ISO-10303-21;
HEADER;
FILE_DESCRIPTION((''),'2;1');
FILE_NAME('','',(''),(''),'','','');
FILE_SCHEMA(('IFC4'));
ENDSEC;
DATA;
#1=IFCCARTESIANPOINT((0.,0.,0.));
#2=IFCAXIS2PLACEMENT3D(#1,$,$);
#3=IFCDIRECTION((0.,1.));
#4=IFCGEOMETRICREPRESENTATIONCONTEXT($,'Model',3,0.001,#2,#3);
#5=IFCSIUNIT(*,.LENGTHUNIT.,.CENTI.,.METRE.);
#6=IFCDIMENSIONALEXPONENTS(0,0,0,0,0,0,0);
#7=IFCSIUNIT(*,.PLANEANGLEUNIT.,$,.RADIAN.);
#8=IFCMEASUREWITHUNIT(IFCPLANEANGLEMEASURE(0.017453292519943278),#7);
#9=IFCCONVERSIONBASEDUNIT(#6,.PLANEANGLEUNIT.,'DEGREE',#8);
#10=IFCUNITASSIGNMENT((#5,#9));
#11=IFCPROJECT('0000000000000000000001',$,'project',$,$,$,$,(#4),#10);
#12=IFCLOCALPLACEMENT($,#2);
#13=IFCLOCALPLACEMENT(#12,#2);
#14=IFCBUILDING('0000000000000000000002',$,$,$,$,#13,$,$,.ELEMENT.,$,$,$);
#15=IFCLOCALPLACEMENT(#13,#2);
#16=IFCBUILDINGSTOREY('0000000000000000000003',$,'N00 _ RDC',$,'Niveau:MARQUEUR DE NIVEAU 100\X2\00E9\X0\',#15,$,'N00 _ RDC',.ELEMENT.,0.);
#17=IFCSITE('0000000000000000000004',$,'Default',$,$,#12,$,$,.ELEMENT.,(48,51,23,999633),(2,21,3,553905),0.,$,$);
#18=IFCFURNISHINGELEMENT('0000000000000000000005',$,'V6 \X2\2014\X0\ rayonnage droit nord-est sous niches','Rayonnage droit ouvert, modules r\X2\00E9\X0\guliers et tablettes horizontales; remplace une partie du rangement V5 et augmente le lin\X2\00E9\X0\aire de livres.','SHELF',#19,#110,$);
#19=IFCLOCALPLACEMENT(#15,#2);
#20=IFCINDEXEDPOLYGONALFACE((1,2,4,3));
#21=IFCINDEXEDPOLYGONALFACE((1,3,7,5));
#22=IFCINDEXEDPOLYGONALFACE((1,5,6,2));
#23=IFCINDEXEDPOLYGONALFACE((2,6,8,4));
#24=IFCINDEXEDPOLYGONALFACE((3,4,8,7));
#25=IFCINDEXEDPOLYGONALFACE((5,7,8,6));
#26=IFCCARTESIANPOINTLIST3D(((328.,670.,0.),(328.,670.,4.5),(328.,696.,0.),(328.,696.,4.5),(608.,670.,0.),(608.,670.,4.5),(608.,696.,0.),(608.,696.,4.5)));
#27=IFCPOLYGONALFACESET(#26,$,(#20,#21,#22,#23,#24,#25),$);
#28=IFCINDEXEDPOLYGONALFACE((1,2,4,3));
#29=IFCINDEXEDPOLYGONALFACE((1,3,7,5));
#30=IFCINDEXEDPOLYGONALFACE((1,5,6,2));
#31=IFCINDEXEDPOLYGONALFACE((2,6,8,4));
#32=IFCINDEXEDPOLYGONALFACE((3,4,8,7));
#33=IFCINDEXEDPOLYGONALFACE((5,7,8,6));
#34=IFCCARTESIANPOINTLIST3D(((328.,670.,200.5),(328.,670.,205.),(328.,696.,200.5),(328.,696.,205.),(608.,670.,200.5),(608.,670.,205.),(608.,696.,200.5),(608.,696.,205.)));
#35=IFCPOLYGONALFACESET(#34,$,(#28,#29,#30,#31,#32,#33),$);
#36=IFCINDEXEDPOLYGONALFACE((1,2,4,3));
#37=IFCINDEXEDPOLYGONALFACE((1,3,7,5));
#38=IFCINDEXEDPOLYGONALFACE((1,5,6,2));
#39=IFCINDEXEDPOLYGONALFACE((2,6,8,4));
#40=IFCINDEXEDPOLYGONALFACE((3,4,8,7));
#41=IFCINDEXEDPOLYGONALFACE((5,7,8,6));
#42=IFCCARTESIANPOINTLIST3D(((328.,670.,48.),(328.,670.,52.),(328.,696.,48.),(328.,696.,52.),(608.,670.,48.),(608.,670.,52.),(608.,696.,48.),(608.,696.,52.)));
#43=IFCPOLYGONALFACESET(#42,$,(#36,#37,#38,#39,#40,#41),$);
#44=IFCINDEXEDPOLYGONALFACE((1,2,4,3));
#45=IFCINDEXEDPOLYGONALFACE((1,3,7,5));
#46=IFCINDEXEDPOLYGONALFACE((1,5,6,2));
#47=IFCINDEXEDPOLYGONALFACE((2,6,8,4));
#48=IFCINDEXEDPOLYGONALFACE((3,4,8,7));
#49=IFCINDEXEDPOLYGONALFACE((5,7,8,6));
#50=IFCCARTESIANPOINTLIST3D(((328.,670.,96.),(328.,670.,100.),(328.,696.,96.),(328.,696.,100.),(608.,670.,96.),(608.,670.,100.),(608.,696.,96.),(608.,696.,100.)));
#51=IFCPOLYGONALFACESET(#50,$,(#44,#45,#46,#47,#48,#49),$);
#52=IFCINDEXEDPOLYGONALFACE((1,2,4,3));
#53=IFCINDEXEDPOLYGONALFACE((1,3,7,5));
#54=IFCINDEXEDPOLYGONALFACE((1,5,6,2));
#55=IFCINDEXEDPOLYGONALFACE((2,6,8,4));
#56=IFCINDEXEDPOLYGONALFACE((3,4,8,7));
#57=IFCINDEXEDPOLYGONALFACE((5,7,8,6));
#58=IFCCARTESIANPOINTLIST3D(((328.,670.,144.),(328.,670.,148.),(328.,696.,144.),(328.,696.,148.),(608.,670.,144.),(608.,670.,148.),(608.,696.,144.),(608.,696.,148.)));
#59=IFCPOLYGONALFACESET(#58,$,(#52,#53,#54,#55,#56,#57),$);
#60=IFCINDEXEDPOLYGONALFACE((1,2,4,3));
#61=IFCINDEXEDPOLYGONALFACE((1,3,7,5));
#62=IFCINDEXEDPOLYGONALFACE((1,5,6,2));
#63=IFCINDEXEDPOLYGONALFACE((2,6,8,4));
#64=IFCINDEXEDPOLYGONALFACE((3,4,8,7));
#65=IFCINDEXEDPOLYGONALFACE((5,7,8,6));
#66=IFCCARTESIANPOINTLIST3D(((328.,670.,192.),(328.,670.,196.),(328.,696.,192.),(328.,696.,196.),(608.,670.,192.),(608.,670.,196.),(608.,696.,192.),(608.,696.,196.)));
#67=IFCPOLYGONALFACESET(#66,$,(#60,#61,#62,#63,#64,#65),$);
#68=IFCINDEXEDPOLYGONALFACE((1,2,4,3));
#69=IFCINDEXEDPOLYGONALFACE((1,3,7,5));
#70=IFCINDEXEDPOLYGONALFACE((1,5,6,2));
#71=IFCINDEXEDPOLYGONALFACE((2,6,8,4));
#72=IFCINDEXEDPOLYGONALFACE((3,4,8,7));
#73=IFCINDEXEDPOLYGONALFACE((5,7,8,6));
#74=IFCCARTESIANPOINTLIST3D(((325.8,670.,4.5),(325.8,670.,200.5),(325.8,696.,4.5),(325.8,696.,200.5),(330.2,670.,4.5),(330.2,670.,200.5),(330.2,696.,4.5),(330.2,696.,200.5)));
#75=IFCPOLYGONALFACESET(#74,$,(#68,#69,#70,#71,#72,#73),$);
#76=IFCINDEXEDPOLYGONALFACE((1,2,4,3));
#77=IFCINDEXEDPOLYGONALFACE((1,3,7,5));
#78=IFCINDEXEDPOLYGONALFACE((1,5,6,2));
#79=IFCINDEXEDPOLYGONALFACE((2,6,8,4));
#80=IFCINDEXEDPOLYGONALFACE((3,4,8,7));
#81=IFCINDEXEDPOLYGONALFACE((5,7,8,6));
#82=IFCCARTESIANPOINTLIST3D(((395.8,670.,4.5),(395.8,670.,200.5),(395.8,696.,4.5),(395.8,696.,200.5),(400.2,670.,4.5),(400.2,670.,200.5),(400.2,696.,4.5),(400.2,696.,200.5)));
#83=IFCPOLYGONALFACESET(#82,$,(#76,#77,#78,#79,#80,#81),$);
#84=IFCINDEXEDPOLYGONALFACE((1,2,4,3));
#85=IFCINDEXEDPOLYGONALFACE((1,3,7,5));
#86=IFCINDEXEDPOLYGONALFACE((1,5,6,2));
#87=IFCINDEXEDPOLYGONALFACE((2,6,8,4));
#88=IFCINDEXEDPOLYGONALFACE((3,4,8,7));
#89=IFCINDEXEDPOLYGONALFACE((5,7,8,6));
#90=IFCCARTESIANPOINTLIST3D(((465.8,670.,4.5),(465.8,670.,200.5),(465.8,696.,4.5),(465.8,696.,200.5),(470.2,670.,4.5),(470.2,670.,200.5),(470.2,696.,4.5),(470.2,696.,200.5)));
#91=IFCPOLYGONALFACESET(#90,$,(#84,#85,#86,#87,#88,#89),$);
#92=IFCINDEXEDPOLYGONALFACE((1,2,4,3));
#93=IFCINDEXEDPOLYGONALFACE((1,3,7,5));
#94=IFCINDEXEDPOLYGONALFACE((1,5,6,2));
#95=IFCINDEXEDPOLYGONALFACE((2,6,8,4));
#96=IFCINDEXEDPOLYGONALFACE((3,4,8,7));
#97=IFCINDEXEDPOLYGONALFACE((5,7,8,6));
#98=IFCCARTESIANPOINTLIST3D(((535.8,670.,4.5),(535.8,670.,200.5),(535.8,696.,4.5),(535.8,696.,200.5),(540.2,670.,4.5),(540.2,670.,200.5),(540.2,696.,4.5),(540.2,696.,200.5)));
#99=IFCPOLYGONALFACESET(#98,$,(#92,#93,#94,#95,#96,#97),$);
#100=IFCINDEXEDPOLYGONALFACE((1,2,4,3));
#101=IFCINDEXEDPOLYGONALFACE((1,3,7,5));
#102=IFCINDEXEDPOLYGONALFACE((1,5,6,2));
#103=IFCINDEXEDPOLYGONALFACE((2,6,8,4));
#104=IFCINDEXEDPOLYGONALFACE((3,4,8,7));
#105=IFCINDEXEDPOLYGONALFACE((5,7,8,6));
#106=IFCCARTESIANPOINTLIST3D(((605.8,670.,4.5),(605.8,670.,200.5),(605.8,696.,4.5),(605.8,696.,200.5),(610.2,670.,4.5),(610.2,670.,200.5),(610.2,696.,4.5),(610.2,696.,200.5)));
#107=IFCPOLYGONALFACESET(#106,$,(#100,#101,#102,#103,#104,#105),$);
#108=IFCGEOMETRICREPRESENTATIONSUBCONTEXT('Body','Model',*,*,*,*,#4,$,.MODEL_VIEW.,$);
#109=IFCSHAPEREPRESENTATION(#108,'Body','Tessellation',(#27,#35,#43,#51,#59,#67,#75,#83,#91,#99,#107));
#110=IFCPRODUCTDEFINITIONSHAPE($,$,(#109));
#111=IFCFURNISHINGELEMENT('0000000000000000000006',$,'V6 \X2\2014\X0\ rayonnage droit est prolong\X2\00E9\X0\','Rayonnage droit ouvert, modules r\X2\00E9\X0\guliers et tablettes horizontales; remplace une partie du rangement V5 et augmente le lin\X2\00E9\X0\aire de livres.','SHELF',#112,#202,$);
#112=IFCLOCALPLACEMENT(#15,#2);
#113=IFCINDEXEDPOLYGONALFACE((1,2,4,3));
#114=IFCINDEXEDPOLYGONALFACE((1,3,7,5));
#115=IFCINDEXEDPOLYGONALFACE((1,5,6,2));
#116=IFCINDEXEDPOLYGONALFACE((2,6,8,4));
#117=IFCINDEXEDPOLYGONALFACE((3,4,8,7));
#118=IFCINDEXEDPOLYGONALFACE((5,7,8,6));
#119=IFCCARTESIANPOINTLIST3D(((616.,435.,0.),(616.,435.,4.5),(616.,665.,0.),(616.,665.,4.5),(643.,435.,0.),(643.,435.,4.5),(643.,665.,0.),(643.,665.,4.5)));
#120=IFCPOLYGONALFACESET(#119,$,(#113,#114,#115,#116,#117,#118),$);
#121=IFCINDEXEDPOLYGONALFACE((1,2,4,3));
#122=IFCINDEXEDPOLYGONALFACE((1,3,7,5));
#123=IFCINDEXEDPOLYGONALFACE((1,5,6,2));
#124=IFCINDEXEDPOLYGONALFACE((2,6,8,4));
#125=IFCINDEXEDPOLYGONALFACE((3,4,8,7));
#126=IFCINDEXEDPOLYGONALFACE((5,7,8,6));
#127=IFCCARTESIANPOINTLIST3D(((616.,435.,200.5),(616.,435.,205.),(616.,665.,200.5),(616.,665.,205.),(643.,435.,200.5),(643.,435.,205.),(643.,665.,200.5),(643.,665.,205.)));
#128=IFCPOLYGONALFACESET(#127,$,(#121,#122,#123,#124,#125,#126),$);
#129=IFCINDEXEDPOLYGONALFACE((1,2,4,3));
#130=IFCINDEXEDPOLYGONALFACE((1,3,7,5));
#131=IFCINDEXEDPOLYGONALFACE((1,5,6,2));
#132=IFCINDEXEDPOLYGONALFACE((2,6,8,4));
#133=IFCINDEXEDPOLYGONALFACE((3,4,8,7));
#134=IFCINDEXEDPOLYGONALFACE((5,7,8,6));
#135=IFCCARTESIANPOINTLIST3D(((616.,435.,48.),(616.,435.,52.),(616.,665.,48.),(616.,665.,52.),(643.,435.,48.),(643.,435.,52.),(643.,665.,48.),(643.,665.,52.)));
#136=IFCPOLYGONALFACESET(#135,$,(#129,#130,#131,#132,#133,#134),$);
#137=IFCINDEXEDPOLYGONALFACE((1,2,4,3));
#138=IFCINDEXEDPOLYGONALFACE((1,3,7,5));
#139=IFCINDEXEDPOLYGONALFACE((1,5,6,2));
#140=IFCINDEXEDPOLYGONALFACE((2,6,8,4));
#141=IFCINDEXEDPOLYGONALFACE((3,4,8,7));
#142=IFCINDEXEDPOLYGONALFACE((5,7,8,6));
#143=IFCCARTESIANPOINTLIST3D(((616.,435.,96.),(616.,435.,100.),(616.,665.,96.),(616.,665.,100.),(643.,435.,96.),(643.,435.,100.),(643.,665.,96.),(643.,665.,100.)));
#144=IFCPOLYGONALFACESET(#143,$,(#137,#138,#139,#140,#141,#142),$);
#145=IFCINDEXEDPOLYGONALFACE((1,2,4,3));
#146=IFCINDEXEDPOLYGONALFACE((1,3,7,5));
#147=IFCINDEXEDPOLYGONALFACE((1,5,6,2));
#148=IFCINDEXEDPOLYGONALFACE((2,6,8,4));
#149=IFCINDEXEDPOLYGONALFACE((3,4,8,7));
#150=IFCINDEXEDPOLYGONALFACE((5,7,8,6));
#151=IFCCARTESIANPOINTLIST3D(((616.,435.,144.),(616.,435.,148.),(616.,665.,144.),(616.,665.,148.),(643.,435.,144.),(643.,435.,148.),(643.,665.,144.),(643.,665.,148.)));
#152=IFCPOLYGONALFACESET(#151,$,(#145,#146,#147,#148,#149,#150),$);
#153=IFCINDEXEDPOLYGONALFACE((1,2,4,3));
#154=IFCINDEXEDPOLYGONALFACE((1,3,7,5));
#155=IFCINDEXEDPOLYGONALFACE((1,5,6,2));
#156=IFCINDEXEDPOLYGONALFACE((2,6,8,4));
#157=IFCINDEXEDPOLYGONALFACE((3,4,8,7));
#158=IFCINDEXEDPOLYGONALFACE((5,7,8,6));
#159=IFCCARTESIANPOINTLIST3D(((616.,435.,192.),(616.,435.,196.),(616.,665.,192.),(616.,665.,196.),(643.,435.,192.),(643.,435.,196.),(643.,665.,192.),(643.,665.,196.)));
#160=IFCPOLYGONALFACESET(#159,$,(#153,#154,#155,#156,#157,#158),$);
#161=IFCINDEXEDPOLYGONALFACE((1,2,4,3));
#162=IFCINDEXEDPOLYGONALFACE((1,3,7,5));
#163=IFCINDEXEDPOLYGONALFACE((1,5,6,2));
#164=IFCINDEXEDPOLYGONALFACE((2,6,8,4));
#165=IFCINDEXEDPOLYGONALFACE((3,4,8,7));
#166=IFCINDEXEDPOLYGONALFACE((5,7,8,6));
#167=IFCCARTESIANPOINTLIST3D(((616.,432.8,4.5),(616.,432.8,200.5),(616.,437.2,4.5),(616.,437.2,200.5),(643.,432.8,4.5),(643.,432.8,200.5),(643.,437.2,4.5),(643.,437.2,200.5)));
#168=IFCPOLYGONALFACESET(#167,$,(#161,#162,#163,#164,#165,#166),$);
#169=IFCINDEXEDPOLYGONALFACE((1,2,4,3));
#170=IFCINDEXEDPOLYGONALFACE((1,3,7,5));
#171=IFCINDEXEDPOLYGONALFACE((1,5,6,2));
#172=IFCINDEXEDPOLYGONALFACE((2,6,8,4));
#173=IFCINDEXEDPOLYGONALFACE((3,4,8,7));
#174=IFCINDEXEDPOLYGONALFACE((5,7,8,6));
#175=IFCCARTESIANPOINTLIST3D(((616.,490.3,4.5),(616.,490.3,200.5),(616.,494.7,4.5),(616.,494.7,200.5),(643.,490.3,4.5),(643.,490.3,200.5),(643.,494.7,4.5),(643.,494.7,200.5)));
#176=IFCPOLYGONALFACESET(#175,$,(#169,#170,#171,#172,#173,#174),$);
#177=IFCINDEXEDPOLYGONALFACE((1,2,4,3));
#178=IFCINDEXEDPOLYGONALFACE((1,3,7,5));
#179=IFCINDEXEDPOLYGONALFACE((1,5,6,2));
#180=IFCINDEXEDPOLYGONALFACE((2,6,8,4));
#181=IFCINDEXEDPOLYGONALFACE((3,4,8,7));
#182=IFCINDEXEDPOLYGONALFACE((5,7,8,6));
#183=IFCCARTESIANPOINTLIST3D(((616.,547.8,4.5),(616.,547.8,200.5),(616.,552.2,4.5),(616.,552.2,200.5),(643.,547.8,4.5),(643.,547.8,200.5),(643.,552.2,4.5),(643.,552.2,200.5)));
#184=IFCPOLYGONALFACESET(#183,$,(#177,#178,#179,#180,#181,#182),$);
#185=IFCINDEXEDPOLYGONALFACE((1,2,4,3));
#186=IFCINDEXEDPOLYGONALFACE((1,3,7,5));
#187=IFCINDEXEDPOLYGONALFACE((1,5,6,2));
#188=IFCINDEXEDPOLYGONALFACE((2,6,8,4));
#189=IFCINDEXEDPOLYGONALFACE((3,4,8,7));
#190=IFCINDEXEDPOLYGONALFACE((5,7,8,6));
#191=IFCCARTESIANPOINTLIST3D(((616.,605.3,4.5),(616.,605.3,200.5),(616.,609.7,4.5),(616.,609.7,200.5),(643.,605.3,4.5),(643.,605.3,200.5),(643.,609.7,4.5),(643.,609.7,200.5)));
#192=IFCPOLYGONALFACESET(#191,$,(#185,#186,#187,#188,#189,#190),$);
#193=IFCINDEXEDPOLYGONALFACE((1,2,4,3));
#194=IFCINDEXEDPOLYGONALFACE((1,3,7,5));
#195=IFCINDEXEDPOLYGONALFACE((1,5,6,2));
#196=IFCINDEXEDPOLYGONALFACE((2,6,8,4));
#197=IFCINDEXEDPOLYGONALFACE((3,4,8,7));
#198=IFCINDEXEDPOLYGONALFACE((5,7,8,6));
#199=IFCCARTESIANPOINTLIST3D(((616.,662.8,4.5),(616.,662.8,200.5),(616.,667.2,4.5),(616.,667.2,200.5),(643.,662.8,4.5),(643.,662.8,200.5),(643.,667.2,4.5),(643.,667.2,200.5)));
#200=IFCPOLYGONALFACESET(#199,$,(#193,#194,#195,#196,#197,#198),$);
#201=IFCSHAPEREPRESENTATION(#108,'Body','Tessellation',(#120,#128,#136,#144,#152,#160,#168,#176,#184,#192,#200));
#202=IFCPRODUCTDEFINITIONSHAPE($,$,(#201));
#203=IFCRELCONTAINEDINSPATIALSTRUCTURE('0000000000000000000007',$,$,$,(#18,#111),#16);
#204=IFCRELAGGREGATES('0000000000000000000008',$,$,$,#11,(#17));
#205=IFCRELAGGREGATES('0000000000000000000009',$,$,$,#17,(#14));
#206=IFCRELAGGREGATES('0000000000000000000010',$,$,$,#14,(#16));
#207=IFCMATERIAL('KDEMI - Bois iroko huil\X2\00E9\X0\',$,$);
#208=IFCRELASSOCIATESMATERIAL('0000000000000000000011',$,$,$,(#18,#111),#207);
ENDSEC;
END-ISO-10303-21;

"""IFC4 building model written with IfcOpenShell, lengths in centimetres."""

from ifc_helpers import new_model, entity, si_unit, converted_unit, direction, frame, frame_2d, origin, origin_with_axes, place, context, subcontext, project, spatial, rectangle, extrude, material, element, save


model = new_model("IFC4")

# Units and contexts
model_context = context("Model", 3, precision=0.001, world=origin(), true_north=direction((0.0, 1.0)))
body_context = subcontext(model_context, "Body", "Model", "MODEL_VIEW")
ifc_project = project(units=[si_unit("LENGTHUNIT", "METRE", prefix="CENTI"), converted_unit("PLANEANGLEUNIT", "DEGREE", entity("IfcPlaneAngleMeasure", 0.017453292519943278), si_unit("PLANEANGLEUNIT", "RADIAN"), dimensions=[0, 0, 0, 0, 0, 0, 0])], contexts=[model_context])

# Site, building, storey
site_placement = place(None, origin())
site = spatial("IfcSite", under=ifc_project, at=site_placement, Name="Default", CompositionType="ELEMENT", RefLatitude=(48, 51, 23, 999633), RefLongitude=(2, 21, 3, 553905), RefElevation=0.0)
building_placement = place(site_placement, origin())
building = spatial("IfcBuilding", under=site, at=building_placement, CompositionType="ELEMENT")
storey_placement = place(building_placement, origin())
storey = spatial("IfcBuildingStorey", under=building, at=storey_placement, Name="N00 _ RDC", ObjectType="Niveau:MARQUEUR DE NIVEAU 100é", LongName="N00 _ RDC", CompositionType="ELEMENT", Elevation=0.0)

# Furnishing elements
ifc_material_1 = material(Name="KDEMI - Bois iroko huilé")
furnishing_1_placement = place(storey_placement, origin_with_axes())
element("IfcFurnishingElement", 1, at=furnishing_1_placement, inside=storey, material=ifc_material_1, Name="V6 — rayonnage droit nord-est sous niches", Description="Rayonnage droit ouvert, modules réguliers et tablettes horizontales; remplace une partie du rangement V5 et augmente le linéaire de livres.", ObjectType="SHELF", context=body_context, shape_type="SweptSolid", body=[
    extrude(rectangle(XDim=280.0, YDim=26.0, at=frame_2d((468.0, 683.0))), origin(), (0.0, 0.0, 1.0), 4.5),
    extrude(rectangle(XDim=280.0, YDim=26.0, at=frame_2d((468.0, 683.0))), frame((0.0, 0.0, 200.5)), (0.0, 0.0, 1.0), 4.5),
    extrude(rectangle(XDim=280.0, YDim=26.0, at=frame_2d((468.0, 683.0))), frame((0.0, 0.0, 48.0)), (0.0, 0.0, 1.0), 4.0),
    extrude(rectangle(XDim=280.0, YDim=26.0, at=frame_2d((468.0, 683.0))), frame((0.0, 0.0, 96.0)), (0.0, 0.0, 1.0), 4.0),
    extrude(rectangle(XDim=280.0, YDim=26.0, at=frame_2d((468.0, 683.0))), frame((0.0, 0.0, 144.0)), (0.0, 0.0, 1.0), 4.0),
    extrude(rectangle(XDim=280.0, YDim=26.0, at=frame_2d((468.0, 683.0))), frame((0.0, 0.0, 192.0)), (0.0, 0.0, 1.0), 4.0),
    extrude(rectangle(XDim=4.4, YDim=26.0, at=frame_2d((328.0, 683.0))), frame((0.0, 0.0, 4.5)), (0.0, 0.0, 1.0), 196.0),
    extrude(rectangle(XDim=4.4, YDim=26.0, at=frame_2d((398.0, 683.0))), frame((0.0, 0.0, 4.5)), (0.0, 0.0, 1.0), 196.0),
    extrude(rectangle(XDim=4.4, YDim=26.0, at=frame_2d((468.0, 683.0))), frame((0.0, 0.0, 4.5)), (0.0, 0.0, 1.0), 196.0),
    extrude(rectangle(XDim=4.4, YDim=26.0, at=frame_2d((538.0, 683.0))), frame((0.0, 0.0, 4.5)), (0.0, 0.0, 1.0), 196.0),
    extrude(rectangle(XDim=4.4, YDim=26.0, at=frame_2d((608.0, 683.0))), frame((0.0, 0.0, 4.5)), (0.0, 0.0, 1.0), 196.0),
])
furnishing_2_placement = place(storey_placement, origin_with_axes())
element("IfcFurnishingElement", 2, at=furnishing_2_placement, inside=storey, material=ifc_material_1, Name="V6 — rayonnage droit est prolongé", Description="Rayonnage droit ouvert, modules réguliers et tablettes horizontales; remplace une partie du rangement V5 et augmente le linéaire de livres.", ObjectType="SHELF", context=body_context, shape_type="SweptSolid", body=[
    extrude(rectangle(XDim=27.0, YDim=230.0, at=frame_2d((629.5, 550.0))), origin(), (0.0, 0.0, 1.0), 4.5),
    extrude(rectangle(XDim=27.0, YDim=230.0, at=frame_2d((629.5, 550.0))), frame((0.0, 0.0, 200.5)), (0.0, 0.0, 1.0), 4.5),
    extrude(rectangle(XDim=27.0, YDim=230.0, at=frame_2d((629.5, 550.0))), frame((0.0, 0.0, 48.0)), (0.0, 0.0, 1.0), 4.0),
    extrude(rectangle(XDim=27.0, YDim=230.0, at=frame_2d((629.5, 550.0))), frame((0.0, 0.0, 96.0)), (0.0, 0.0, 1.0), 4.0),
    extrude(rectangle(XDim=27.0, YDim=230.0, at=frame_2d((629.5, 550.0))), frame((0.0, 0.0, 144.0)), (0.0, 0.0, 1.0), 4.0),
    extrude(rectangle(XDim=27.0, YDim=230.0, at=frame_2d((629.5, 550.0))), frame((0.0, 0.0, 192.0)), (0.0, 0.0, 1.0), 4.0),
    extrude(rectangle(XDim=27.0, YDim=4.4, at=frame_2d((629.5, 435.0))), frame((0.0, 0.0, 4.5)), (0.0, 0.0, 1.0), 196.0),
    extrude(rectangle(XDim=27.0, YDim=4.4, at=frame_2d((629.5, 492.5))), frame((0.0, 0.0, 4.5)), (0.0, 0.0, 1.0), 196.0),
    extrude(rectangle(XDim=27.0, YDim=4.4, at=frame_2d((629.5, 550.0))), frame((0.0, 0.0, 4.5)), (0.0, 0.0, 1.0), 196.0),
    extrude(rectangle(XDim=27.0, YDim=4.4, at=frame_2d((629.5, 607.5))), frame((0.0, 0.0, 4.5)), (0.0, 0.0, 1.0), 196.0),
    extrude(rectangle(XDim=27.0, YDim=4.4, at=frame_2d((629.5, 665.0))), frame((0.0, 0.0, 4.5)), (0.0, 0.0, 1.0), 196.0),
])

save(model, "model.ifc")
